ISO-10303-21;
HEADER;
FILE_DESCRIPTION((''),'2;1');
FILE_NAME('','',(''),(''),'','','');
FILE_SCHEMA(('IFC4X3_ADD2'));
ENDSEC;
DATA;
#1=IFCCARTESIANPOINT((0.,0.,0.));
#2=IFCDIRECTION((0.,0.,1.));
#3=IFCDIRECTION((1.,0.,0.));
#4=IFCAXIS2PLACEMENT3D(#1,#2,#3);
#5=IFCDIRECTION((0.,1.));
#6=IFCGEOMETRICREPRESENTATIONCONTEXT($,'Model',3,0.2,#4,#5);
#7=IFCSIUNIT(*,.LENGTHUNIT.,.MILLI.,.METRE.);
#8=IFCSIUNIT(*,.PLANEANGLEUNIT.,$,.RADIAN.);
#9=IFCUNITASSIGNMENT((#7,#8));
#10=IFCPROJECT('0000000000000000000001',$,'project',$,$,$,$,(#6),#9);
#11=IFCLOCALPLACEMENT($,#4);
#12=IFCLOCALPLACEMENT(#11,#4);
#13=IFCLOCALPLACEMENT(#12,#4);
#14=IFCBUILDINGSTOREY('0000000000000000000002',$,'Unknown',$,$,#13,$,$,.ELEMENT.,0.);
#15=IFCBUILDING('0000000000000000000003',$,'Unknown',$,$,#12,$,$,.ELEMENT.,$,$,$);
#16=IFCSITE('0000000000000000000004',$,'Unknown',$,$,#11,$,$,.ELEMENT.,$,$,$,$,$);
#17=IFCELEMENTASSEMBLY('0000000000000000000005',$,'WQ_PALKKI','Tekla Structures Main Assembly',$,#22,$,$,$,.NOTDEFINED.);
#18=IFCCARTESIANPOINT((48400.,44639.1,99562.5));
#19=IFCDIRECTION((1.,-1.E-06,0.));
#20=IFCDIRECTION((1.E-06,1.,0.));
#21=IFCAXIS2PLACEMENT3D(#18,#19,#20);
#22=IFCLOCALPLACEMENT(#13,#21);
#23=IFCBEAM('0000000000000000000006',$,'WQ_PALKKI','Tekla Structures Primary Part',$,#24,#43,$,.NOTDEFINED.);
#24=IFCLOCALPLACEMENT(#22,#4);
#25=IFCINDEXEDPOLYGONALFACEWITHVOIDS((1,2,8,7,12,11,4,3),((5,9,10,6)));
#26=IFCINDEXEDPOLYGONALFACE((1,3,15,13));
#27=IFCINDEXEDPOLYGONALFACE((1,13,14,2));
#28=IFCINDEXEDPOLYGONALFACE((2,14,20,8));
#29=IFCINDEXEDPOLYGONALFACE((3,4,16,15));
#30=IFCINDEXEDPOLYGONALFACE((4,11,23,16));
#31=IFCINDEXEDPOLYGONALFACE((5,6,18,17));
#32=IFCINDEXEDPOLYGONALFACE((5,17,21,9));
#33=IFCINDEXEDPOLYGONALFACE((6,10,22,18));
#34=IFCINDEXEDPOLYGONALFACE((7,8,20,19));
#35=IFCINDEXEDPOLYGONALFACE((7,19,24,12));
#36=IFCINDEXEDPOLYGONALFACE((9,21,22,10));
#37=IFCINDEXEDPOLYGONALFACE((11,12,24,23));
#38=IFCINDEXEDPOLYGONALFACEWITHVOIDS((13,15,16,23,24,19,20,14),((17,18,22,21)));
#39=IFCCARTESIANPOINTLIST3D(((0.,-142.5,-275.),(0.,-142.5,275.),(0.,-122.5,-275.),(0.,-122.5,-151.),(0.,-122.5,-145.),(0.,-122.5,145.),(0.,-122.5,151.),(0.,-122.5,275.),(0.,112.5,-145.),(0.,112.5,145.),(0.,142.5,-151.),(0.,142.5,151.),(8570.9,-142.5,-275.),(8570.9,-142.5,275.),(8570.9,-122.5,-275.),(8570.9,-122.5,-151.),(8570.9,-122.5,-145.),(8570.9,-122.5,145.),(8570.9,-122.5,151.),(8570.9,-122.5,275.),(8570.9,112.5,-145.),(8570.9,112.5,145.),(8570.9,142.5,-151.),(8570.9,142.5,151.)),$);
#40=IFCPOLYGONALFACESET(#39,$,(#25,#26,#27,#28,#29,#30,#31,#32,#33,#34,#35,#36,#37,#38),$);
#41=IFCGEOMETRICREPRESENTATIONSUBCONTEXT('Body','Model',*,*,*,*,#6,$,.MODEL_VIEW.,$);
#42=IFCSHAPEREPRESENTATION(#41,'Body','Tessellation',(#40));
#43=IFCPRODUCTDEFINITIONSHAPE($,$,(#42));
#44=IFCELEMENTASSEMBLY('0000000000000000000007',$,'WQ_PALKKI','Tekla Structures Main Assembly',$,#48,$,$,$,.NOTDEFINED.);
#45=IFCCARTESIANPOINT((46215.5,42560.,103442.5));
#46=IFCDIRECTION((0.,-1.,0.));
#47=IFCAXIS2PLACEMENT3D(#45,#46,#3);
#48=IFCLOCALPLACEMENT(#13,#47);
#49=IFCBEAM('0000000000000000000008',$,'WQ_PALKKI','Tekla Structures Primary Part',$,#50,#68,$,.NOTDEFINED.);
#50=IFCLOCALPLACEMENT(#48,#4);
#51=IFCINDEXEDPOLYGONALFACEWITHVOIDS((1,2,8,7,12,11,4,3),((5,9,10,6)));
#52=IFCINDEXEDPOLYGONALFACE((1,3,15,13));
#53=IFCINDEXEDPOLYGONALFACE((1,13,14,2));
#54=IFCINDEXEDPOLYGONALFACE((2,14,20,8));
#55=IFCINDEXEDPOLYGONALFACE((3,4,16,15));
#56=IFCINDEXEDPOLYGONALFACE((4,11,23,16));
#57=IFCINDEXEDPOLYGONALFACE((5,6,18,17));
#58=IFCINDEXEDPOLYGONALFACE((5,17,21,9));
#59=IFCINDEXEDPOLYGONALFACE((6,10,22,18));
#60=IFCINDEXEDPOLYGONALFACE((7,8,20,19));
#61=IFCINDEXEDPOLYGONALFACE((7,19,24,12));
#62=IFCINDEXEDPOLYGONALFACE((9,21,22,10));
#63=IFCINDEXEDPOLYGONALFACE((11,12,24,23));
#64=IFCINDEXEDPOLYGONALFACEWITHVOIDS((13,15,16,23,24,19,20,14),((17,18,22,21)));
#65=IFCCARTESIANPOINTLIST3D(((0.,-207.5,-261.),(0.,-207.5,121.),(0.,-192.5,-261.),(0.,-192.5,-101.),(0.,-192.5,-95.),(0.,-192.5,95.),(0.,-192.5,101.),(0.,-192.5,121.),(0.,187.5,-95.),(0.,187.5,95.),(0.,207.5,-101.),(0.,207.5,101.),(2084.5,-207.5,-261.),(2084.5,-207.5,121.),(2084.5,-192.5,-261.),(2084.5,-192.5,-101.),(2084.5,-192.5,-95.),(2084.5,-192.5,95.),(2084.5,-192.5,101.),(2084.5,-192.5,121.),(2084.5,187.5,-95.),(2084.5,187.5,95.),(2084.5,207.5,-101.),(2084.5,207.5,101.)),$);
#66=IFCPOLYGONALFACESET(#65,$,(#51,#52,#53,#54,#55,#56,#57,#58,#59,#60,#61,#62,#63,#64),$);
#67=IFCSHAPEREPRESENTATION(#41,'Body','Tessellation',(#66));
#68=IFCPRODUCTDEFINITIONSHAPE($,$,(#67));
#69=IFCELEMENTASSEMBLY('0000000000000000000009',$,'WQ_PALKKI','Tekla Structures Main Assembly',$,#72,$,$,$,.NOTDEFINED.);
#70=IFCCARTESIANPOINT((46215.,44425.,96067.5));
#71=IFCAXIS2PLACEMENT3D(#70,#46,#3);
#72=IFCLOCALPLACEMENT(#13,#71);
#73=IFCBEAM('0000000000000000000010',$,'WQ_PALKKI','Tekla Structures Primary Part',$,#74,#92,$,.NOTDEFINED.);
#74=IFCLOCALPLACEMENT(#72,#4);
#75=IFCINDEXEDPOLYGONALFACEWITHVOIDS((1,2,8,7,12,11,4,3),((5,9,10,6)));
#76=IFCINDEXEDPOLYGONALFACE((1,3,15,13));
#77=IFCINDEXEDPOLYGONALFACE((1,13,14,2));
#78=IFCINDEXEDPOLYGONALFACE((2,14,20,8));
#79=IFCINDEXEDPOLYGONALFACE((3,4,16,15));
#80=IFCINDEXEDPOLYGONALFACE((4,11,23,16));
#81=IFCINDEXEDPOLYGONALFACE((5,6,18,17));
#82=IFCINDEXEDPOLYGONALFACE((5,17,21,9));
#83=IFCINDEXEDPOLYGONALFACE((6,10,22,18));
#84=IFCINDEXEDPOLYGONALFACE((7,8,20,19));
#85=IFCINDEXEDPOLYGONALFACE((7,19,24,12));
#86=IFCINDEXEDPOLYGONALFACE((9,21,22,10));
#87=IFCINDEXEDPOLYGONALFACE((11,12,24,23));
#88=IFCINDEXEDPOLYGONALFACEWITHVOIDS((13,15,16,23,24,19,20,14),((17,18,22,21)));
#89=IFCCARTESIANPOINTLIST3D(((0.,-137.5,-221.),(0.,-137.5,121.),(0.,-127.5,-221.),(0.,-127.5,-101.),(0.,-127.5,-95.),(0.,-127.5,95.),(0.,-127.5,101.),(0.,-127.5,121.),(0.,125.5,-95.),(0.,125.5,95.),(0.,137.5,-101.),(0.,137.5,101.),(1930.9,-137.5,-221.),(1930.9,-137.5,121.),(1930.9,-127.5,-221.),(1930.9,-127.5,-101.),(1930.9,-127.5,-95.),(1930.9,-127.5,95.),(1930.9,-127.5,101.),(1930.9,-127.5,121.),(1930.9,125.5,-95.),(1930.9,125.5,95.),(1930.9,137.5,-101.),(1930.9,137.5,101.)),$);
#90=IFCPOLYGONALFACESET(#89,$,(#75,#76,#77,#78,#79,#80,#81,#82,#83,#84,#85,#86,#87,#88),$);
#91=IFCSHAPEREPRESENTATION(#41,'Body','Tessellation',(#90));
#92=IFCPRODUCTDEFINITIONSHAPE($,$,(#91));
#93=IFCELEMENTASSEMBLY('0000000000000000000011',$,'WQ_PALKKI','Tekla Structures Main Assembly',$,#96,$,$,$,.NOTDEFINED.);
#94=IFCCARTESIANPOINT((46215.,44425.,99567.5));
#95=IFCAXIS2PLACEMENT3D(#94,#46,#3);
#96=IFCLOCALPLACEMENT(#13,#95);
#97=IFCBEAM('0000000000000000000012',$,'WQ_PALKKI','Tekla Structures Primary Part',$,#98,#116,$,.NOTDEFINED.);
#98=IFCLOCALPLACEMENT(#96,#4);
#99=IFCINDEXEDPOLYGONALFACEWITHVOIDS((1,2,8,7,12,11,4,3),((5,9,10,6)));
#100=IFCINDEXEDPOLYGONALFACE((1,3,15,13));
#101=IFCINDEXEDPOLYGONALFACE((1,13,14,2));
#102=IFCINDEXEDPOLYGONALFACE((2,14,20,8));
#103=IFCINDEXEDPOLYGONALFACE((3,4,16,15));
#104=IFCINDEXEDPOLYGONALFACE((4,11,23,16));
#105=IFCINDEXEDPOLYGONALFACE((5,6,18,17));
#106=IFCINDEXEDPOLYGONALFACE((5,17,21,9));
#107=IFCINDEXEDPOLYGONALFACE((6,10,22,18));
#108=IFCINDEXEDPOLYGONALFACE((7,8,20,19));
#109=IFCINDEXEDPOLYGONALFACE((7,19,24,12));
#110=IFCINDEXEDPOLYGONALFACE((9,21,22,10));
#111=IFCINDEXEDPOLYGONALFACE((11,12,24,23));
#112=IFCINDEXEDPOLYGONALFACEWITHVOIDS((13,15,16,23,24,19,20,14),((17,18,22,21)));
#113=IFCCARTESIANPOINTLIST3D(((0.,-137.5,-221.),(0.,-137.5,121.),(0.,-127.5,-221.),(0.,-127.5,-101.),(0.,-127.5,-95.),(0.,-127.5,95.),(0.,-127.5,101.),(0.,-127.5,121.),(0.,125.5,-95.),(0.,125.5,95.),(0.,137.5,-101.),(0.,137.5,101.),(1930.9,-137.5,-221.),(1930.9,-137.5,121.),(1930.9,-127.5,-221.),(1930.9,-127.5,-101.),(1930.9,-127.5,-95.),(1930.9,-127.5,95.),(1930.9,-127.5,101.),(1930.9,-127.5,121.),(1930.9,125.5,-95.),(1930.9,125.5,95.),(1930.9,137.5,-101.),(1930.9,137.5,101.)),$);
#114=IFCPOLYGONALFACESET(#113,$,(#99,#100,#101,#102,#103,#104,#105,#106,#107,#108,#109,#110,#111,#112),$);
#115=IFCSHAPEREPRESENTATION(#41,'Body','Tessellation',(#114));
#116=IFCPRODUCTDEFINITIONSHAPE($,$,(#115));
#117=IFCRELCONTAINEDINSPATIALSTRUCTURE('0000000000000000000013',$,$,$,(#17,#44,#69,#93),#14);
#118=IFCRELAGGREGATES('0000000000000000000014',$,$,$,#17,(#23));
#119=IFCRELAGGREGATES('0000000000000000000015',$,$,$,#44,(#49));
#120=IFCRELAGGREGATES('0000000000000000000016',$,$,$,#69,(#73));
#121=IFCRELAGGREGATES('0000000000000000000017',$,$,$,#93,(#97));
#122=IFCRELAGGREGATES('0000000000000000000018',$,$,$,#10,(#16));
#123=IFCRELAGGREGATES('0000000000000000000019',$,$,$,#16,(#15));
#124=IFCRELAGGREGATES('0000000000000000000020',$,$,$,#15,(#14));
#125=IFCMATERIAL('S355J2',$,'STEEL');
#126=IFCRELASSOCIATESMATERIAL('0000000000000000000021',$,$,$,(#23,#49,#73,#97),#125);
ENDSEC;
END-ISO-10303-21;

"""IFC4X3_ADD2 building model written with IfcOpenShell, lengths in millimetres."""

from ifc_helpers import new_model, si_unit, direction, frame, origin_with_axes, place, context, subcontext, project, spatial, line, indexed_curve, outline, extrude, material, element, aggregate, save


model = new_model("IFC4X3_ADD2")

# Units and contexts
model_context = context("Model", 3, precision=0.2, world=origin_with_axes(), true_north=direction((0.0, 1.0)))
body_context = subcontext(model_context, "Body", "Model", "MODEL_VIEW")
ifc_project = project(units=[si_unit("LENGTHUNIT", "METRE", prefix="MILLI"), si_unit("PLANEANGLEUNIT", "RADIAN")], contexts=[model_context])

# Site, building, storey
site_placement = place(None, origin_with_axes())
site = spatial("IfcSite", under=ifc_project, at=site_placement, Name="Unknown", CompositionType="ELEMENT")
building_placement = place(site_placement, origin_with_axes())
building = spatial("IfcBuilding", under=site, at=building_placement, Name="Unknown", CompositionType="ELEMENT")
storey_placement = place(building_placement, origin_with_axes())
storey = spatial("IfcBuildingStorey", under=building, at=storey_placement, Name="Unknown", CompositionType="ELEMENT", Elevation=0.0)

# Element assemblies, beams
assembly_1_placement = place(storey_placement, frame((48400.0, 44639.1, 99562.5), z_axis=(1.0, -0.000001, 0.0), x_axis=(0.000001, 1.0, 0.0)))
assembly_1 = element("IfcElementAssembly", 1, at=assembly_1_placement, inside=storey, Name="WQ_PALKKI", Description="Tekla Structures Main Assembly", PredefinedType="NOTDEFINED")
ifc_material_1 = material(Name="S355J2", Category="STEEL")
beam_1_placement = place(assembly_1_placement, origin_with_axes())
beam_1 = element("IfcBeam", 2, at=beam_1_placement, material=ifc_material_1, Name="WQ_PALKKI", Description="Tekla Structures Primary Part", PredefinedType="NOTDEFINED", context=body_context, shape_type="SolidModel", body=[
    extrude(outline(indexed_curve([(-275.0, -142.5), (275.0, -142.5), (275.0, -122.5), (151.0, -122.5), (151.0, 142.5), (-151.0, 142.5), (-151.0, -122.5), (-275.0, -122.5)], segments=[line(1, 2, 3, 4, 5, 6, 7, 8, 1)]), holes=[indexed_curve([(-145.0, -122.5), (-145.0, 112.5), (145.0, 112.5), (145.0, -122.5)], segments=[line(1, 2, 3, 4, 1)])]), frame((0.0, 0.0, 0.0), z_axis=(-1.0, 0.0, 0.0), x_axis=(0.0, 0.0, 1.0)), (0.0, 0.0, -1.0), 8570.9),
])
aggregate(assembly_1, [beam_1])
assembly_2_placement = place(storey_placement, frame((46215.5, 42560.0, 103442.5), z_axis=(0.0, -1.0, 0.0), x_axis=(1.0, 0.0, 0.0)))
assembly_2 = element("IfcElementAssembly", 3, at=assembly_2_placement, inside=storey, Name="WQ_PALKKI", Description="Tekla Structures Main Assembly", PredefinedType="NOTDEFINED")
beam_2_placement = place(assembly_2_placement, origin_with_axes())
beam_2 = element("IfcBeam", 4, at=beam_2_placement, material=ifc_material_1, Name="WQ_PALKKI", Description="Tekla Structures Primary Part", PredefinedType="NOTDEFINED", context=body_context, shape_type="SolidModel", body=[
    extrude(outline(indexed_curve([(-261.0, -207.5), (121.0, -207.5), (121.0, -192.5), (101.0, -192.5), (101.0, 207.5), (-101.0, 207.5), (-101.0, -192.5), (-261.0, -192.5)], segments=[line(1, 2, 3, 4, 5, 6, 7, 8, 1)]), holes=[indexed_curve([(-95.0, -192.5), (-95.0, 187.5), (95.0, 187.5), (95.0, -192.5)], segments=[line(1, 2, 3, 4, 1)])]), frame((0.0, 0.0, 0.0), z_axis=(-1.0, 0.0, 0.0), x_axis=(0.0, 0.0, 1.0)), (0.0, 0.0, -1.0), 2084.5),
])
aggregate(assembly_2, [beam_2])
assembly_3_placement = place(storey_placement, frame((46215.0, 44425.0, 96067.5), z_axis=(0.0, -1.0, 0.0), x_axis=(1.0, 0.0, 0.0)))
assembly_3 = element("IfcElementAssembly", 5, at=assembly_3_placement, inside=storey, Name="WQ_PALKKI", Description="Tekla Structures Main Assembly", PredefinedType="NOTDEFINED")
beam_3_placement = place(assembly_3_placement, origin_with_axes())
beam_3 = element("IfcBeam", 6, at=beam_3_placement, material=ifc_material_1, Name="WQ_PALKKI", Description="Tekla Structures Primary Part", PredefinedType="NOTDEFINED", context=body_context, shape_type="SolidModel", body=[
    extrude(outline(indexed_curve([(-221.0, -137.5), (121.0, -137.5), (121.0, -127.5), (101.0, -127.5), (101.0, 137.5), (-101.0, 137.5), (-101.0, -127.5), (-221.0, -127.5)], segments=[line(1, 2, 3, 4, 5, 6, 7, 8, 1)]), holes=[indexed_curve([(-95.0, -127.5), (-95.0, 125.5), (95.0, 125.5), (95.0, -127.5)], segments=[line(1, 2, 3, 4, 1)])]), frame((0.0, 0.0, 0.0), z_axis=(-1.0, 0.0, 0.0), x_axis=(0.0, 0.0, 1.0)), (0.0, 0.0, -1.0), 1930.9),
])
aggregate(assembly_3, [beam_3])

# Element assembly, beam
assembly_4_placement = place(storey_placement, frame((46215.0, 44425.0, 99567.5), z_axis=(0.0, -1.0, 0.0), x_axis=(1.0, 0.0, 0.0)))
assembly_4 = element("IfcElementAssembly", 7, at=assembly_4_placement, inside=storey, Name="WQ_PALKKI", Description="Tekla Structures Main Assembly", PredefinedType="NOTDEFINED")
beam_4_placement = place(assembly_4_placement, origin_with_axes())
beam_4 = element("IfcBeam", 8, at=beam_4_placement, material=ifc_material_1, Name="WQ_PALKKI", Description="Tekla Structures Primary Part", PredefinedType="NOTDEFINED", context=body_context, shape_type="SolidModel", body=[
    extrude(outline(indexed_curve([(-221.0, -137.5), (121.0, -137.5), (121.0, -127.5), (101.0, -127.5), (101.0, 137.5), (-101.0, 137.5), (-101.0, -127.5), (-221.0, -127.5)], segments=[line(1, 2, 3, 4, 5, 6, 7, 8, 1)]), holes=[indexed_curve([(-95.0, -127.5), (-95.0, 125.5), (95.0, 125.5), (95.0, -127.5)], segments=[line(1, 2, 3, 4, 1)])]), frame((0.0, 0.0, 0.0), z_axis=(-1.0, 0.0, 0.0), x_axis=(0.0, 0.0, 1.0)), (0.0, 0.0, -1.0), 1930.9),
])
aggregate(assembly_4, [beam_4])

save(model, "model.ifc")
